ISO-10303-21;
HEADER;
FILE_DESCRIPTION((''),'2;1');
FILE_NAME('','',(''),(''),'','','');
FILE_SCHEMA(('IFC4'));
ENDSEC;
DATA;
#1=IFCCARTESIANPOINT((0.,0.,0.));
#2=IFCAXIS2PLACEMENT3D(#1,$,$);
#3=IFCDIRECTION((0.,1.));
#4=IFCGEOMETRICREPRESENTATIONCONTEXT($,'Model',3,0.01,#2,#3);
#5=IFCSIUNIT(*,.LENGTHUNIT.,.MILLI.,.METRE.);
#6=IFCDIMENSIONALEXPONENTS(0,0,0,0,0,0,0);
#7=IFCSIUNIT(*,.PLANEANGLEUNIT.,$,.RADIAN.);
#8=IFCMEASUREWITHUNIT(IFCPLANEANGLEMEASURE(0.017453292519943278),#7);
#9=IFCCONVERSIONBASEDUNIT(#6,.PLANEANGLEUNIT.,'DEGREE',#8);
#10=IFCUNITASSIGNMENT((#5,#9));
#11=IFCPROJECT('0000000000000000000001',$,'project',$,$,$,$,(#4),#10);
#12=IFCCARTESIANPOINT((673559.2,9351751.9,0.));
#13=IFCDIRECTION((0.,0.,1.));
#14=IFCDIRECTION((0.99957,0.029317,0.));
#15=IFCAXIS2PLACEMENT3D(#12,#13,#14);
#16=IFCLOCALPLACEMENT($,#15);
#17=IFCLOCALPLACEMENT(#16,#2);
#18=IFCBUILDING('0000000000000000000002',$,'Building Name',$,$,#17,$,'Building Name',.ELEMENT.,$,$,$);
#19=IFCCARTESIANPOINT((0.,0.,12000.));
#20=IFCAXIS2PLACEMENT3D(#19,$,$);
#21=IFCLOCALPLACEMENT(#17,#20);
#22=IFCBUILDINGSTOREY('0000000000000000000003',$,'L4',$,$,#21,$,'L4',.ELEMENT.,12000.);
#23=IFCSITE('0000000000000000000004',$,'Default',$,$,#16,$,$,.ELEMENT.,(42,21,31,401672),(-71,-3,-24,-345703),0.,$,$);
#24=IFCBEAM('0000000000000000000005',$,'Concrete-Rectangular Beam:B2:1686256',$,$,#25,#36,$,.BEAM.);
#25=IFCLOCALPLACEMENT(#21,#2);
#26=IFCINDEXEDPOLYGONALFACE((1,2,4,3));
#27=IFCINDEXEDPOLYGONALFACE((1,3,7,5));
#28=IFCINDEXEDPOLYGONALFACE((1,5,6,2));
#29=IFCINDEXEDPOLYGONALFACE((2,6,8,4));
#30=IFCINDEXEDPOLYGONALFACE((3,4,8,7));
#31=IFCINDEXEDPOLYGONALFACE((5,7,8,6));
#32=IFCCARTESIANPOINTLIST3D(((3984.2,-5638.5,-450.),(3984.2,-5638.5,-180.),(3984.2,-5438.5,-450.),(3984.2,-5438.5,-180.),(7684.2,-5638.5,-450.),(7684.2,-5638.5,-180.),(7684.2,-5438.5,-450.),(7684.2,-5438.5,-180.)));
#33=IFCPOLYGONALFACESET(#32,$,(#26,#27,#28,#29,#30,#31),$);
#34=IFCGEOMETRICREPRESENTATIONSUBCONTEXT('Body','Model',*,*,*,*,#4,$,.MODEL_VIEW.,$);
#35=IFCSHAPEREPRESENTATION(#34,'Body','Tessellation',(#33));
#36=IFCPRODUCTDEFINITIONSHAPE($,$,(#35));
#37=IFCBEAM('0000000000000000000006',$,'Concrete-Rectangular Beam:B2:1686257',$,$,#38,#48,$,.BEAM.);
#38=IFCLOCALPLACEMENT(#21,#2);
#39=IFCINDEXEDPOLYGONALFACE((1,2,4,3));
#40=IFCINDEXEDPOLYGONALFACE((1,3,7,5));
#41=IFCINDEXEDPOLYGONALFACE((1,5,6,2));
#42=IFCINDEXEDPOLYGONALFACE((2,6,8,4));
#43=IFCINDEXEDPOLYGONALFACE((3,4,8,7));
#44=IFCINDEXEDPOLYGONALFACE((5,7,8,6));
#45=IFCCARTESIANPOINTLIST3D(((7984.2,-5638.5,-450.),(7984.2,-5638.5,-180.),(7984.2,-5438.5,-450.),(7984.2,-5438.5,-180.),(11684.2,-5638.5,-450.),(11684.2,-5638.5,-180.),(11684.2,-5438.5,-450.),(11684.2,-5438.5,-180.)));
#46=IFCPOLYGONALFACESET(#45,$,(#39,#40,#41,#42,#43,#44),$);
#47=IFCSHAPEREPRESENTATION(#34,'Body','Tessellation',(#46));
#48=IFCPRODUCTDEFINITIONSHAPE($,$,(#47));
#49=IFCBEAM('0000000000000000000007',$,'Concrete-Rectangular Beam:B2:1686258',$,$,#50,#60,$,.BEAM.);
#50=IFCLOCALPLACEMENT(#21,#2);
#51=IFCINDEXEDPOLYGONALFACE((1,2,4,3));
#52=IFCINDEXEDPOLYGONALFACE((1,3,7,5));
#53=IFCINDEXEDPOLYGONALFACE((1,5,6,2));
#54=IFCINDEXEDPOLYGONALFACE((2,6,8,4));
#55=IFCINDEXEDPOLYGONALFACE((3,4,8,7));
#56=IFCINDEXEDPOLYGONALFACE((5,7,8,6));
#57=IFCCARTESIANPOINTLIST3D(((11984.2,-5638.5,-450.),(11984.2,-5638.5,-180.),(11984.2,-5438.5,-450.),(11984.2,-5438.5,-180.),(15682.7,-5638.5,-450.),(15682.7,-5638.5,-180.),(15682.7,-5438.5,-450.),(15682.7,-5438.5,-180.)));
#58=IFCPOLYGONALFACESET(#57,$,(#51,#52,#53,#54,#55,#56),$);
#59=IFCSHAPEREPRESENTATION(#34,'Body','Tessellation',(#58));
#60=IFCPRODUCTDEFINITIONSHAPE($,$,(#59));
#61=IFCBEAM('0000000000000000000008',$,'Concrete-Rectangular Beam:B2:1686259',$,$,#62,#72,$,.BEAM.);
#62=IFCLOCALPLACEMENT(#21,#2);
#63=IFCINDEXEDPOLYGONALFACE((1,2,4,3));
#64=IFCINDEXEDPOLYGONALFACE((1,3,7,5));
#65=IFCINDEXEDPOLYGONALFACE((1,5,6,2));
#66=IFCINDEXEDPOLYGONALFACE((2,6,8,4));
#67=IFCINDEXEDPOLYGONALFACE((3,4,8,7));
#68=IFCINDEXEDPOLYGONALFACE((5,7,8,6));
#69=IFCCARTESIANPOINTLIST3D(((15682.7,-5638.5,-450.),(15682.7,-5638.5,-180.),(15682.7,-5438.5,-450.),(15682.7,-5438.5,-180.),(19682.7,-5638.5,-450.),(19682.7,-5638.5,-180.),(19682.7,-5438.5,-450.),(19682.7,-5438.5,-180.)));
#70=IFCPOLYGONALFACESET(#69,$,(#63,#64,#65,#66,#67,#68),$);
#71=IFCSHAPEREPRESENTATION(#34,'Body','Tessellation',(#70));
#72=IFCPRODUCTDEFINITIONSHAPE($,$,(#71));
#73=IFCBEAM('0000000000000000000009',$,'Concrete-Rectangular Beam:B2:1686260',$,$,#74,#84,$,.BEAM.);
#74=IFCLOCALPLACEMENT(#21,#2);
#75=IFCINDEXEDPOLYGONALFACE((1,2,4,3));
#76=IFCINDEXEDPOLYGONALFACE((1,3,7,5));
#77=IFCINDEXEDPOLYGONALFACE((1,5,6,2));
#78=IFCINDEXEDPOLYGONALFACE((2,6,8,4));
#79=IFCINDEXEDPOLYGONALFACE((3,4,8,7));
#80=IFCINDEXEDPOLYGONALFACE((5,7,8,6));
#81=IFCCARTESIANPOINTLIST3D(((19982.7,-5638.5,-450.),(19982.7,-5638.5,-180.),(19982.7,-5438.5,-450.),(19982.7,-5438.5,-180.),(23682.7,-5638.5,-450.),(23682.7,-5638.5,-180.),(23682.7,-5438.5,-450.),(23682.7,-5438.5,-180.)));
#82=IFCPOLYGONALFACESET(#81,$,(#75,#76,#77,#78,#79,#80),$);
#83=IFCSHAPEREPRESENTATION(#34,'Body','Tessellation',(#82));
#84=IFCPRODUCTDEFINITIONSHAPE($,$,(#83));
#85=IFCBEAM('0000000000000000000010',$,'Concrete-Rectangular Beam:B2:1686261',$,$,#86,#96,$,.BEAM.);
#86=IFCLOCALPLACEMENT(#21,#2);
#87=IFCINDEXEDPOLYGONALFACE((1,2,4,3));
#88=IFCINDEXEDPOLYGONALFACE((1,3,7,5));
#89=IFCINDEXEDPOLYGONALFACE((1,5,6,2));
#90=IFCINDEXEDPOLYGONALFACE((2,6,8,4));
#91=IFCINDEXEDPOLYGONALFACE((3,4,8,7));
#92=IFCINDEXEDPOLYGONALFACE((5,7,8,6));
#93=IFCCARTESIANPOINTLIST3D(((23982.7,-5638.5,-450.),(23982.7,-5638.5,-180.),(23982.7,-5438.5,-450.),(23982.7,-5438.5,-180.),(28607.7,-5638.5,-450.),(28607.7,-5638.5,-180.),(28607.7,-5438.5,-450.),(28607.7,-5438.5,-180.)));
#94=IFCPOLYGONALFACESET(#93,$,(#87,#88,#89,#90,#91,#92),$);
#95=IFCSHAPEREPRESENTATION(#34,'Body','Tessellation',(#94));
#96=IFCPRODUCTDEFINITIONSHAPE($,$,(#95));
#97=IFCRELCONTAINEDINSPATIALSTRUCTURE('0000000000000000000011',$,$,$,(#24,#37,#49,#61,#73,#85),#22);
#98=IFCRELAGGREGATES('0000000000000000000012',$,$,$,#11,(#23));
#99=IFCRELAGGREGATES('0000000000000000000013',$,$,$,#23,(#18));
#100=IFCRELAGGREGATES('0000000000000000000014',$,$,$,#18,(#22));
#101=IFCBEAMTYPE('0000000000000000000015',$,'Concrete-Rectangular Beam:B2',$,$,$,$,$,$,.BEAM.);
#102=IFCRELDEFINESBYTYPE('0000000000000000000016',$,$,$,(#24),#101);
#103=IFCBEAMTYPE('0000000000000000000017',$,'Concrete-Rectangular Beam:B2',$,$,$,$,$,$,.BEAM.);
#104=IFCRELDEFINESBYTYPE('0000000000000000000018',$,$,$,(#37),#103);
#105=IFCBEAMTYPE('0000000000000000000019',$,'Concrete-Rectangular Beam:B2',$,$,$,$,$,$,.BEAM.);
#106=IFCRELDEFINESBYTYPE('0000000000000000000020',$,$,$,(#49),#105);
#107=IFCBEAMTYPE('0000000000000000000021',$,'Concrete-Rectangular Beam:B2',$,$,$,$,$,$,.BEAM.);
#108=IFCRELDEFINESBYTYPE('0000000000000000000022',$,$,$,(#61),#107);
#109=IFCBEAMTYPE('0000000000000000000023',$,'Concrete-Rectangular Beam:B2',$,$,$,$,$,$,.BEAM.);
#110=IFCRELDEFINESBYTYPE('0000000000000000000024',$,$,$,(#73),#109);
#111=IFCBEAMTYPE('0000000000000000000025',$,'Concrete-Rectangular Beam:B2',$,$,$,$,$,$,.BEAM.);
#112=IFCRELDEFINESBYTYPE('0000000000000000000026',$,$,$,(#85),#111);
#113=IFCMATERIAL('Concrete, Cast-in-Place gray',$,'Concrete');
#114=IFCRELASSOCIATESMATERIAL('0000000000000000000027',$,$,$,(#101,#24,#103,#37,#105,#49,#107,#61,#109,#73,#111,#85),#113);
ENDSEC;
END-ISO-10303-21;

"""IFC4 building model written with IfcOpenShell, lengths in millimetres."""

from ifc_helpers import new_model, entity, si_unit, converted_unit, direction, frame, origin, place, context, subcontext, project, spatial, indexed_curve, outline, extrude, source, transform, mapped, material, type_object, type_shapes, element, save


model = new_model("IFC4")

# Units and contexts
model_context = context("Model", 3, precision=0.01, world=origin(), true_north=direction((0.0, 1.0)))
body_context = subcontext(model_context, "Body", "Model", "MODEL_VIEW")
ifc_project = project(units=[si_unit("LENGTHUNIT", "METRE", prefix="MILLI"), converted_unit("PLANEANGLEUNIT", "DEGREE", entity("IfcPlaneAngleMeasure", 0.017453292519943278), si_unit("PLANEANGLEUNIT", "RADIAN"), dimensions=[0, 0, 0, 0, 0, 0, 0])], contexts=[model_context])

# Site, building, storey
site_placement = place(None, frame((673559.2, 9351751.9, 0.0), z_axis=(0.0, 0.0, 1.0), x_axis=(0.99957, 0.029317, 0.0)))
site = spatial("IfcSite", under=ifc_project, at=site_placement, Name="Default", CompositionType="ELEMENT", RefLatitude=(42, 21, 31, 401672), RefLongitude=(-71, -3, -24, -345703), RefElevation=0.0)
building_placement = place(site_placement, origin())
building = spatial("IfcBuilding", under=site, at=building_placement, Name="Building Name", LongName="Building Name", CompositionType="ELEMENT")
storey_placement = place(building_placement, frame((0.0, 0.0, 12000.0)))
storey = spatial("IfcBuildingStorey", under=building, at=storey_placement, Name="L4", LongName="L4", CompositionType="ELEMENT", Elevation=12000.0)

# Beams
ifc_material = material(Name="Concrete, Cast-in-Place gray", Category="Concrete")
beam_type_1 = type_object("IfcBeamType", Name="Concrete-Rectangular Beam:B2", PredefinedType="BEAM", material=ifc_material)
shared_shape_1 = source(origin(), body_context, "Body", "SweptSolid", [
    extrude(outline(indexed_curve([(-135.0, -100.0), (135.0, -100.0), (135.0, 100.0), (-135.0, 100.0), (-135.0, -100.0)], self_intersect=False)), frame((3984.2, -5538.5, 11685.0), z_axis=(1.0, 0.0, 0.0), x_axis=(0.0, 0.0, -1.0)), (0.0, 0.0, 1.0), 3700.0),
])
type_shapes(beam_type_1, [shared_shape_1])
beam_1_placement = place(storey_placement, frame((0.0, 0.0, -12000.0)))
element("IfcBeam", 1, at=beam_1_placement, inside=storey, type_object=beam_type_1, material=ifc_material, Name="Concrete-Rectangular Beam:B2:1686256", PredefinedType="BEAM", context=body_context, shape_type="MappedRepresentation", body=[
    mapped(shared_shape_1, transform((0.0, 0.0, 0.0), scale=1.0)),
])
beam_type_2 = type_object("IfcBeamType", Name="Concrete-Rectangular Beam:B2", PredefinedType="BEAM", material=ifc_material)
shared_shape_2 = source(origin(), body_context, "Body", "SweptSolid", [
    extrude(outline(indexed_curve([(-135.0, -100.0), (135.0, -100.0), (135.0, 100.0), (-135.0, 100.0), (-135.0, -100.0)], self_intersect=False)), frame((7984.2, -5538.5, 11685.0), z_axis=(1.0, 0.0, 0.0), x_axis=(0.0, 0.0, -1.0)), (0.0, 0.0, 1.0), 3700.0),
])
type_shapes(beam_type_2, [shared_shape_2])
beam_2_placement = place(storey_placement, frame((0.0, 0.0, -12000.0)))
element("IfcBeam", 2, at=beam_2_placement, inside=storey, type_object=beam_type_2, material=ifc_material, Name="Concrete-Rectangular Beam:B2:1686257", PredefinedType="BEAM", context=body_context, shape_type="MappedRepresentation", body=[
    mapped(shared_shape_2, transform((0.0, 0.0, 0.0), scale=1.0)),
])
beam_type_3 = type_object("IfcBeamType", Name="Concrete-Rectangular Beam:B2", PredefinedType="BEAM", material=ifc_material)
shared_shape_3 = source(origin(), body_context, "Body", "SweptSolid", [
    extrude(outline(indexed_curve([(-135.0, -100.0), (135.0, -100.0), (135.0, 100.0), (-135.0, 100.0), (-135.0, -100.0)], self_intersect=False)), frame((11984.2, -5538.5, 11685.0), z_axis=(1.0, 0.0, 0.0), x_axis=(0.0, 0.0, -1.0)), (0.0, 0.0, 1.0), 3698.5),
])
type_shapes(beam_type_3, [shared_shape_3])
beam_3_placement = place(storey_placement, frame((0.0, 0.0, -12000.0)))
element("IfcBeam", 3, at=beam_3_placement, inside=storey, type_object=beam_type_3, material=ifc_material, Name="Concrete-Rectangular Beam:B2:1686258", PredefinedType="BEAM", context=body_context, shape_type="MappedRepresentation", body=[
    mapped(shared_shape_3, transform((0.0, 0.0, 0.0), scale=1.0)),
])
beam_type_4 = type_object("IfcBeamType", Name="Concrete-Rectangular Beam:B2", PredefinedType="BEAM", material=ifc_material)
shared_shape_4 = source(origin(), body_context, "Body", "SweptSolid", [
    extrude(outline(indexed_curve([(-135.0, -100.0), (135.0, -100.0), (135.0, 100.0), (-135.0, 100.0), (-135.0, -100.0)], self_intersect=False)), frame((15682.7, -5538.5, 11685.0), z_axis=(1.0, 0.0, 0.0), x_axis=(0.0, 0.0, -1.0)), (0.0, 0.0, 1.0), 4000.0),
])
type_shapes(beam_type_4, [shared_shape_4])
beam_4_placement = place(storey_placement, frame((0.0, 0.0, -12000.0)))
element("IfcBeam", 4, at=beam_4_placement, inside=storey, type_object=beam_type_4, material=ifc_material, Name="Concrete-Rectangular Beam:B2:1686259", PredefinedType="BEAM", context=body_context, shape_type="MappedRepresentation", body=[
    mapped(shared_shape_4, transform((0.0, 0.0, 0.0), scale=1.0)),
])
beam_type_5 = type_object("IfcBeamType", Name="Concrete-Rectangular Beam:B2", PredefinedType="BEAM", material=ifc_material)
shared_shape_5 = source(origin(), body_context, "Body", "SweptSolid", [
    extrude(outline(indexed_curve([(-135.0, -100.0), (135.0, -100.0), (135.0, 100.0), (-135.0, 100.0), (-135.0, -100.0)], self_intersect=False)), frame((19982.7, -5538.5, 11685.0), z_axis=(1.0, 0.0, 0.0), x_axis=(0.0, 0.0, -1.0)), (0.0, 0.0, 1.0), 3700.0),
])
type_shapes(beam_type_5, [shared_shape_5])
beam_5_placement = place(storey_placement, frame((0.0, 0.0, -12000.0)))
element("IfcBeam", 5, at=beam_5_placement, inside=storey, type_object=beam_type_5, material=ifc_material, Name="Concrete-Rectangular Beam:B2:1686260", PredefinedType="BEAM", context=body_context, shape_type="MappedRepresentation", body=[
    mapped(shared_shape_5, transform((0.0, 0.0, 0.0), scale=1.0)),
])
beam_type_6 = type_object("IfcBeamType", Name="Concrete-Rectangular Beam:B2", PredefinedType="BEAM", material=ifc_material)
shared_shape_6 = source(origin(), body_context, "Body", "SweptSolid", [
    extrude(outline(indexed_curve([(-135.0, -100.0), (135.0, -100.0), (135.0, 100.0), (-135.0, 100.0), (-135.0, -100.0)], self_intersect=False)), frame((23982.7, -5538.5, 11685.0), z_axis=(1.0, 0.0, 0.0), x_axis=(0.0, 0.0, -1.0)), (0.0, 0.0, 1.0), 4625.0),
])
type_shapes(beam_type_6, [shared_shape_6])
beam_6_placement = place(storey_placement, frame((0.0, 0.0, -12000.0)))
element("IfcBeam", 6, at=beam_6_placement, inside=storey, type_object=beam_type_6, material=ifc_material, Name="Concrete-Rectangular Beam:B2:1686261", PredefinedType="BEAM", context=body_context, shape_type="MappedRepresentation", body=[
    mapped(shared_shape_6, transform((0.0, 0.0, 0.0), scale=1.0)),
])

save(model, "model.ifc")
